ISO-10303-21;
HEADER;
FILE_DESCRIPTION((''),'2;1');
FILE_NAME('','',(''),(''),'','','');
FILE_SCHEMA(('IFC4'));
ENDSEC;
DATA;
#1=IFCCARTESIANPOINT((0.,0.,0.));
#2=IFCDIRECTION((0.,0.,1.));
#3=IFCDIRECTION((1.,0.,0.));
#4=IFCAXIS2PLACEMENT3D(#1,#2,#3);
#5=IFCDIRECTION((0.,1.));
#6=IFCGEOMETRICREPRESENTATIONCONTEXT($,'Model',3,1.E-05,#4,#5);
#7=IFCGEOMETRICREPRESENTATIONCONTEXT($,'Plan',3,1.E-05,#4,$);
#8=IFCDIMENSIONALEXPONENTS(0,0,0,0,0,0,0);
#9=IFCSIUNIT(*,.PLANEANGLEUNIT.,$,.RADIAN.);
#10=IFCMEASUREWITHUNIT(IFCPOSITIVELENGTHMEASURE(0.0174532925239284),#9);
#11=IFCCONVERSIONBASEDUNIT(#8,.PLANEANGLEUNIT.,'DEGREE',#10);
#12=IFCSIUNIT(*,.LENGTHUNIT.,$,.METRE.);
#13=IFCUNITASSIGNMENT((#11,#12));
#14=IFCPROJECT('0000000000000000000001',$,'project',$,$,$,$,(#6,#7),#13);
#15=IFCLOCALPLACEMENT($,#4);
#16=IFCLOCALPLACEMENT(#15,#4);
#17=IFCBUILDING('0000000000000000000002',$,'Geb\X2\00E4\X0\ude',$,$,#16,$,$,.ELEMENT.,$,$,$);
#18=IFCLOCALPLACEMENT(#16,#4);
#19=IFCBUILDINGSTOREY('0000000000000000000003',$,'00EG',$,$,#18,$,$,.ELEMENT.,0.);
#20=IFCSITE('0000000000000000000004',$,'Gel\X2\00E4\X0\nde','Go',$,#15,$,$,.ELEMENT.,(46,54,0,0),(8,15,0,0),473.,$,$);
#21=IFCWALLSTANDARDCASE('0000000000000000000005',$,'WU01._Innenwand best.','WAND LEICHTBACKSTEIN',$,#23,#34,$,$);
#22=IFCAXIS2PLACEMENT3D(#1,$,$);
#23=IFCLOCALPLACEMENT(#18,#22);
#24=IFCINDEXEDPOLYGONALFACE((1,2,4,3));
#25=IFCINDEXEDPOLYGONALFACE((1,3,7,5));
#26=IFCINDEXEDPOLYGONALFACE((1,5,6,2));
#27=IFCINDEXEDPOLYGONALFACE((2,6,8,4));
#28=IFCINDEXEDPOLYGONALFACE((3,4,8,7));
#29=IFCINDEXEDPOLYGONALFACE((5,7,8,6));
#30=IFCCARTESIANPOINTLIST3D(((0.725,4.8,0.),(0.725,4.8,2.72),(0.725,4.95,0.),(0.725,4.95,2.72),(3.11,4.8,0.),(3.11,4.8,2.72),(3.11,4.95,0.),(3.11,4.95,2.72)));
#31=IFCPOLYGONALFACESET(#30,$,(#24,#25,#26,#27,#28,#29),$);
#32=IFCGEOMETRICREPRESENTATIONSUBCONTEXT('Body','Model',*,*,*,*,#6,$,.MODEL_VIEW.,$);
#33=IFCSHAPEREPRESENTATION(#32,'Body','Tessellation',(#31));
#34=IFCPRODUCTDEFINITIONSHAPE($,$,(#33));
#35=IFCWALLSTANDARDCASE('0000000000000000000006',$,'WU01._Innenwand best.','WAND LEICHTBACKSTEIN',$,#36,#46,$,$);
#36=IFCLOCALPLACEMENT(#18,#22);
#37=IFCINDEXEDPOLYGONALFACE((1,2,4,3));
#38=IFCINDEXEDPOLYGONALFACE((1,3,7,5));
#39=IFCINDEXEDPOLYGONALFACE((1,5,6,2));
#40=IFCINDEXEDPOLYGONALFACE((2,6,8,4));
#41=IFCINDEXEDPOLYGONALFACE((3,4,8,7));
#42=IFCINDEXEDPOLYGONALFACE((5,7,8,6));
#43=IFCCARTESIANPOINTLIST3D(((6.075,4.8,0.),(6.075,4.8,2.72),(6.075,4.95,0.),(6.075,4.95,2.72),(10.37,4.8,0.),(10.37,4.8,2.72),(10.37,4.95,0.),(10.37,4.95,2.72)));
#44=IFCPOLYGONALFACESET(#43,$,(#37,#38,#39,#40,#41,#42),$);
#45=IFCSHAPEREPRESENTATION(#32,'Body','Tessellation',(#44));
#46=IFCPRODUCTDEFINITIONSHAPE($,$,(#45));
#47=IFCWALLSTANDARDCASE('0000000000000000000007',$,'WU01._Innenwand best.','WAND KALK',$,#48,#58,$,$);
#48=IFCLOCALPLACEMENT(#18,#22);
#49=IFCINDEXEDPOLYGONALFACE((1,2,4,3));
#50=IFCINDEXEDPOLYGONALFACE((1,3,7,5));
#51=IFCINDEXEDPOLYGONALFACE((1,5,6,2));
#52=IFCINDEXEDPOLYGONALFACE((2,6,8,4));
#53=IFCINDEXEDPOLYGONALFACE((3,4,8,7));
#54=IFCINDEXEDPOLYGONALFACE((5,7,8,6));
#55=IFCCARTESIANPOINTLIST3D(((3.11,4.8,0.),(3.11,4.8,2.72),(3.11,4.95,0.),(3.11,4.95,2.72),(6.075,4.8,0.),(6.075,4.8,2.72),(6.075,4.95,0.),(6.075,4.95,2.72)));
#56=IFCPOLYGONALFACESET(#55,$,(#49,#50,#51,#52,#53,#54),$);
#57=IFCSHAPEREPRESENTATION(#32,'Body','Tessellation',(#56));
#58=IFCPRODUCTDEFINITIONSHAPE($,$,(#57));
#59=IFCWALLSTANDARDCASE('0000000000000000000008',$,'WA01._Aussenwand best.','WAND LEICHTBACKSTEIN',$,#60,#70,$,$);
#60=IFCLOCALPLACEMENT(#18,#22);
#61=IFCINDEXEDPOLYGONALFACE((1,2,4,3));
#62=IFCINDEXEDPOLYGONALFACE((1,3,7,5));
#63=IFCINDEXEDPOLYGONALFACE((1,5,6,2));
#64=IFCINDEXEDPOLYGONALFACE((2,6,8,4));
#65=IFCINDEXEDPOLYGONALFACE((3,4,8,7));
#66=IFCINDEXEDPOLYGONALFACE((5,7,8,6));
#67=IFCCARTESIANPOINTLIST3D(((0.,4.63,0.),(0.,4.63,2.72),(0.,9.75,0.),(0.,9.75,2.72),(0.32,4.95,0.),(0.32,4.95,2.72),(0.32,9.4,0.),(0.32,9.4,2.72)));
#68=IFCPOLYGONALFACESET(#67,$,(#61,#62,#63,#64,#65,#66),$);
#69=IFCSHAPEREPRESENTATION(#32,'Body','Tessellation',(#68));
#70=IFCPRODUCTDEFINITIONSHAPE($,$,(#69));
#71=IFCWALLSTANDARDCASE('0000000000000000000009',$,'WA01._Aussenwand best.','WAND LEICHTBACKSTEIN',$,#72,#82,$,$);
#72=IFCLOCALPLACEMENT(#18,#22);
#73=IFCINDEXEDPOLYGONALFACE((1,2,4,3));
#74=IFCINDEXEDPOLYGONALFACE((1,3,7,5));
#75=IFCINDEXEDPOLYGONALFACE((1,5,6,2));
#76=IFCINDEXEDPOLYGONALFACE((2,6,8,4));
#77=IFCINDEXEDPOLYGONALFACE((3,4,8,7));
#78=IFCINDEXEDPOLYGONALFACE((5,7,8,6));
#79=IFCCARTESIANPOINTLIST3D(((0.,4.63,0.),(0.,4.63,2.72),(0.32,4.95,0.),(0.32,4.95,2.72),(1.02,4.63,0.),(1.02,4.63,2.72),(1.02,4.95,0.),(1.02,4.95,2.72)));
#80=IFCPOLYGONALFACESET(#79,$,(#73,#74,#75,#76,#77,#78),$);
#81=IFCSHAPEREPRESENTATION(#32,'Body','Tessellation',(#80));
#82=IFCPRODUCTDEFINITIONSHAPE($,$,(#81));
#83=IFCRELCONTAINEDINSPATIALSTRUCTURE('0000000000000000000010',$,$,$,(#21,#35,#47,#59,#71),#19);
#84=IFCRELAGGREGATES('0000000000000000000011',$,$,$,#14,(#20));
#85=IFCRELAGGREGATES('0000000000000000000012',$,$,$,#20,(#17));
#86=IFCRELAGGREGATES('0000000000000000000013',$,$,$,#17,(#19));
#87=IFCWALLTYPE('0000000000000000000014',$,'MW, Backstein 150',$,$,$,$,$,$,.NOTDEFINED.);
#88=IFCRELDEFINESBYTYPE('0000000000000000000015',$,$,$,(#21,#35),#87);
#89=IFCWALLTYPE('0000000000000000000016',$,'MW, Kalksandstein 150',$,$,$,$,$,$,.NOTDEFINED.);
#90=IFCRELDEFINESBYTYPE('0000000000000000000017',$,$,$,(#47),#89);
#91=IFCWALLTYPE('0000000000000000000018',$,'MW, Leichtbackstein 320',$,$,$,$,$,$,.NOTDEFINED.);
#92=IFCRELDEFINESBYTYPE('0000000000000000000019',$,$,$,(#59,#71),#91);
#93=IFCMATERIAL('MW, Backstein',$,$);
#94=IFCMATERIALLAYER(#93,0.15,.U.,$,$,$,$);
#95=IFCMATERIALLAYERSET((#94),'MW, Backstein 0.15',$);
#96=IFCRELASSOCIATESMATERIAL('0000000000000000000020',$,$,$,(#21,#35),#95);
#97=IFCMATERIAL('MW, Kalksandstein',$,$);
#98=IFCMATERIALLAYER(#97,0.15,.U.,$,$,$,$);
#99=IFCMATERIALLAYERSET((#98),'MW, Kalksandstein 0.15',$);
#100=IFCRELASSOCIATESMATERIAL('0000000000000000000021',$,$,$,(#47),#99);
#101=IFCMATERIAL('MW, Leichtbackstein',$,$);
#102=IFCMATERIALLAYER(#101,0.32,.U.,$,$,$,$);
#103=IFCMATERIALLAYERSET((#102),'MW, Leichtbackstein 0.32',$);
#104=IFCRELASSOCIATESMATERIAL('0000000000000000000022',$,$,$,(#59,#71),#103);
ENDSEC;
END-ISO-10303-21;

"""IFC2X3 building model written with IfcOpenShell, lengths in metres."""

from ifc_helpers import new_model, entity, si_unit, converted_unit, direction, frame, origin_with_axes, place, context, subcontext, project, spatial, polyline, outline, extrude, material, layer, layer_set, layer_usage, type_object, element, save


model = new_model("IFC2X3")

# Units and contexts
model_context = context("Model", 3, precision=1e-05, world=origin_with_axes(), true_north=direction((0.0, 1.0)))
plan_context = context("Plan", 3, precision=1e-05, world=origin_with_axes())
body_context = subcontext(model_context, "Body", "Model", "MODEL_VIEW")
ifc_project = project(units=[converted_unit("PLANEANGLEUNIT", "DEGREE", entity("IfcPositiveLengthMeasure", 0.0174532925239284), si_unit("PLANEANGLEUNIT", "RADIAN"), dimensions=[0, 0, 0, 0, 0, 0, 0]), si_unit("LENGTHUNIT", "METRE")], contexts=[model_context, plan_context])

# Site, building, storey
site_placement = place(None, origin_with_axes())
site = spatial("IfcSite", under=ifc_project, at=site_placement, Name="Gelände", Description="Go", CompositionType="ELEMENT", RefLatitude=(46, 54, 0, 0), RefLongitude=(8, 15, 0, 0), RefElevation=473.0)
building_placement = place(site_placement, origin_with_axes())
building = spatial("IfcBuilding", under=site, at=building_placement, Name="Gebäude", CompositionType="ELEMENT")
storey_placement = place(building_placement, origin_with_axes())
storey = spatial("IfcBuildingStorey", under=building, at=storey_placement, Name="00EG", CompositionType="ELEMENT", Elevation=0.0)

# Walls
ifc_material_1 = material(Name="MW, Backstein")
ifc_layer_1 = layer(ifc_material_1, 0.15, ventilated="UNKNOWN")
ifc_layer_set_1 = layer_set([ifc_layer_1], Name="MW, Backstein 0.15")
ifc_layer_usage_1 = layer_usage(ifc_layer_set_1, "AXIS2", "POSITIVE", -0.15)
wall_type_1 = type_object("IfcWallType", Name="MW, Backstein 150", PredefinedType="NOTDEFINED")
wall_1_placement = place(storey_placement, frame((0.725, 4.95, 0.0), z_axis=(0.0, 0.0, 1.0), x_axis=(1.0, 0.0, 0.0)))
element("IfcWallStandardCase", 1, at=wall_1_placement, inside=storey, type_object=wall_type_1, material=ifc_layer_usage_1, Name="WU01._Innenwand best.", Description="WAND LEICHTBACKSTEIN", context=body_context, shape_type="SweptSolid", body=[
    extrude(outline(polyline([(0.0, -0.15), (2.385, -0.15), (2.385, 0.0), (0.0, 0.0), (0.0, -0.15)])), origin_with_axes(), (0.0, 0.0, 1.0), 2.72),
])
ifc_layer_usage_2 = layer_usage(ifc_layer_set_1, "AXIS2", "POSITIVE", -0.15)
wall_2_placement = place(storey_placement, frame((6.075, 4.95, 0.0), z_axis=(0.0, 0.0, 1.0), x_axis=(1.0, 0.0, 0.0)))
element("IfcWallStandardCase", 2, at=wall_2_placement, inside=storey, type_object=wall_type_1, material=ifc_layer_usage_2, Name="WU01._Innenwand best.", Description="WAND LEICHTBACKSTEIN", context=body_context, shape_type="SweptSolid", body=[
    extrude(outline(polyline([(0.0, -0.15), (4.295, -0.15), (4.295, 0.0), (0.0, 0.0), (0.0, -0.15)])), origin_with_axes(), (0.0, 0.0, 1.0), 2.72),
])
ifc_material_2 = material(Name="MW, Kalksandstein")
ifc_layer_2 = layer(ifc_material_2, 0.15, ventilated="UNKNOWN")
ifc_layer_set_2 = layer_set([ifc_layer_2], Name="MW, Kalksandstein 0.15")
ifc_layer_usage_3 = layer_usage(ifc_layer_set_2, "AXIS2", "POSITIVE", -0.15)
wall_type_2 = type_object("IfcWallType", Name="MW, Kalksandstein 150", PredefinedType="NOTDEFINED")
wall_3_placement = place(storey_placement, frame((3.11, 4.95, 0.0), z_axis=(0.0, 0.0, 1.0), x_axis=(1.0, 0.0, 0.0)))
element("IfcWallStandardCase", 3, at=wall_3_placement, inside=storey, type_object=wall_type_2, material=ifc_layer_usage_3, Name="WU01._Innenwand best.", Description="WAND KALK", context=body_context, shape_type="SweptSolid", body=[
    extrude(outline(polyline([(0.0, -0.15), (2.965, -0.15), (2.965, 0.0), (0.0, 0.0), (0.0, -0.15)])), origin_with_axes(), (0.0, 0.0, 1.0), 2.72),
])
ifc_material_3 = material(Name="MW, Leichtbackstein")
ifc_layer_3 = layer(ifc_material_3, 0.32, ventilated="UNKNOWN")
ifc_layer_set_3 = layer_set([ifc_layer_3], Name="MW, Leichtbackstein 0.32")
ifc_layer_usage_4 = layer_usage(ifc_layer_set_3, "AXIS2", "POSITIVE", -0.32)
wall_type_3 = type_object("IfcWallType", Name="MW, Leichtbackstein 320", PredefinedType="NOTDEFINED")
wall_4_placement = place(storey_placement, frame((0.32, 9.4, 0.0), z_axis=(0.0, 0.0, 1.0), x_axis=(0.0, -1.0, 0.0)))
element("IfcWallStandardCase", 4, at=wall_4_placement, inside=storey, type_object=wall_type_3, material=ifc_layer_usage_4, Name="WA01._Aussenwand best.", Description="WAND LEICHTBACKSTEIN", context=body_context, shape_type="SweptSolid", body=[
    extrude(outline(polyline([(-0.35, -0.32), (4.77, -0.32), (4.45, 0.0), (0.0, 0.0), (-0.35, -0.32)])), origin_with_axes(), (0.0, 0.0, 1.0), 2.72),
])
ifc_layer_usage_5 = layer_usage(ifc_layer_set_3, "AXIS2", "POSITIVE", -0.32)
wall_5_placement = place(storey_placement, frame((0.32, 4.95, 0.0), z_axis=(0.0, 0.0, 1.0), x_axis=(1.0, 0.0, 0.0)))
element("IfcWallStandardCase", 5, at=wall_5_placement, inside=storey, type_object=wall_type_3, material=ifc_layer_usage_5, Name="WA01._Aussenwand best.", Description="WAND LEICHTBACKSTEIN", context=body_context, shape_type="SweptSolid", body=[
    extrude(outline(polyline([(-0.32, -0.32), (0.7, -0.32), (0.7, 0.0), (0.0, 0.0), (-0.32, -0.32)])), origin_with_axes(), (0.0, 0.0, 1.0), 2.72),
])

save(model, "model.ifc")
